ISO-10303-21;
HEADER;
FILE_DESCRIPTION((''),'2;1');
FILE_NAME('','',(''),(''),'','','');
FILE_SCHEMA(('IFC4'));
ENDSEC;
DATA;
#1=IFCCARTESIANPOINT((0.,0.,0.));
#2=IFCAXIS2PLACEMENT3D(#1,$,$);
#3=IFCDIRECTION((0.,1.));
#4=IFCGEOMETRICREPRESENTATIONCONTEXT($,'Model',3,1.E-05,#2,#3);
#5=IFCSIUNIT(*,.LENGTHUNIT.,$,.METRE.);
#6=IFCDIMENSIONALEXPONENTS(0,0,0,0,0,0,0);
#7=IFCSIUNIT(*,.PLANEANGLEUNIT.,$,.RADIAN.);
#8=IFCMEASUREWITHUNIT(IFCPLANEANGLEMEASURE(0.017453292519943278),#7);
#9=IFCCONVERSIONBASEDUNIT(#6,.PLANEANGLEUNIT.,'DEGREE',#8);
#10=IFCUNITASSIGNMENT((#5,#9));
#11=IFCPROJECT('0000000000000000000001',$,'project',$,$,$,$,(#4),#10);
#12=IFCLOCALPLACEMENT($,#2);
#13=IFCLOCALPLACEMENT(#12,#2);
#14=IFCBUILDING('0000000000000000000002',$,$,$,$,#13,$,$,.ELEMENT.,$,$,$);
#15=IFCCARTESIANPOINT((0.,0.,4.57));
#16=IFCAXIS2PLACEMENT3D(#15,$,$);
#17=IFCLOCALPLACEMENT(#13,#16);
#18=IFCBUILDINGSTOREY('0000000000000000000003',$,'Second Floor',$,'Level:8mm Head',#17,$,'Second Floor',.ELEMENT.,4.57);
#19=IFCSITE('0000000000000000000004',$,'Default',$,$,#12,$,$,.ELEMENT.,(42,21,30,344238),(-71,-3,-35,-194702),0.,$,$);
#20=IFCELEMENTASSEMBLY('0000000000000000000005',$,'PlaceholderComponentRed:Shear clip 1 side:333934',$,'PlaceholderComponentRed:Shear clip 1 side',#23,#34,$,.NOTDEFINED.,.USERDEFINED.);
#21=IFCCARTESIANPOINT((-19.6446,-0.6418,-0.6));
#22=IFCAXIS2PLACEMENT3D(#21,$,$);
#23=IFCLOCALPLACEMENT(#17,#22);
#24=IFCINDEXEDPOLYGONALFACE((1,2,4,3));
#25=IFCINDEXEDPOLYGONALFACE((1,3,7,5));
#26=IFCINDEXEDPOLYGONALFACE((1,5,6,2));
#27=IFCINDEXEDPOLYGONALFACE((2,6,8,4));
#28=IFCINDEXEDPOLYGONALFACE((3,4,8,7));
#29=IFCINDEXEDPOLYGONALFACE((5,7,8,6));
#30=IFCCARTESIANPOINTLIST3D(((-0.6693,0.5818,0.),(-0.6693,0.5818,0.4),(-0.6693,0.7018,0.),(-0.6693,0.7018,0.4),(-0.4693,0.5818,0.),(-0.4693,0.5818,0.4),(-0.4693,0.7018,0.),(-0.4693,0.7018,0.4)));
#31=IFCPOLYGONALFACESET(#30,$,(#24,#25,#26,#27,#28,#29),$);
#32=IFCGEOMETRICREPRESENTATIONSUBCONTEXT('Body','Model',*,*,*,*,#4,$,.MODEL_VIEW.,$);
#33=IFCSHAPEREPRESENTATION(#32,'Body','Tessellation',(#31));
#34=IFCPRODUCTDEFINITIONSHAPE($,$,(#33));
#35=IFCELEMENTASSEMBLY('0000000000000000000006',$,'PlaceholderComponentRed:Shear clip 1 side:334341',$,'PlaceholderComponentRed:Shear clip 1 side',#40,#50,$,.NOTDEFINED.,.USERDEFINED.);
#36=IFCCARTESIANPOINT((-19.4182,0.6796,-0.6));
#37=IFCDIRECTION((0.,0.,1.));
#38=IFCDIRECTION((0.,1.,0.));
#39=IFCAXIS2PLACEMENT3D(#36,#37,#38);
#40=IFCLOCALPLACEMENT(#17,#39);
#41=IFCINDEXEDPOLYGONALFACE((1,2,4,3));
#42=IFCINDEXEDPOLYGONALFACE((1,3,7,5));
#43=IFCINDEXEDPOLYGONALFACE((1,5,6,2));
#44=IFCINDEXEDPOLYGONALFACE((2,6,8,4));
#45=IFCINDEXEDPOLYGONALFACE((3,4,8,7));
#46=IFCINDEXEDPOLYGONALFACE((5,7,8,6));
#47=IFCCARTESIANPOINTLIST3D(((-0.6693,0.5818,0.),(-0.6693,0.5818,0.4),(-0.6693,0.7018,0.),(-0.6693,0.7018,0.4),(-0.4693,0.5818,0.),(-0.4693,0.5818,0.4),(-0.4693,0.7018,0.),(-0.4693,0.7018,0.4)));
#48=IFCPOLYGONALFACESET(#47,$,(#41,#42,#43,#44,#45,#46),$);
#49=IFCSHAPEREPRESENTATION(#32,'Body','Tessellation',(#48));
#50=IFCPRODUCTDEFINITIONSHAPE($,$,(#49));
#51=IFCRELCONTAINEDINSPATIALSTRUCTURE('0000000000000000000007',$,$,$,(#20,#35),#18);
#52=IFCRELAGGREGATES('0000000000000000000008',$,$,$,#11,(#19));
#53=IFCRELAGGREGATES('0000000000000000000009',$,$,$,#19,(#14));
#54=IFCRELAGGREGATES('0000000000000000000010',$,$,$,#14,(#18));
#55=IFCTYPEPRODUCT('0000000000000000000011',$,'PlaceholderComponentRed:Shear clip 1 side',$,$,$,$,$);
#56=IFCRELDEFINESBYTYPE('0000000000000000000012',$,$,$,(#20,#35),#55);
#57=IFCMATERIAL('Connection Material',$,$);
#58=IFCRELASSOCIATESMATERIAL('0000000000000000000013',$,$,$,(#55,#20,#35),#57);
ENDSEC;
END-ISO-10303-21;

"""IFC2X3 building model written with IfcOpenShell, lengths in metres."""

from ifc_helpers import new_model, entity, si_unit, converted_unit, direction, frame, frame_2d, origin, place, context, subcontext, project, spatial, rectangle, extrude, source, transform, mapped, material, type_object, type_shapes, element, save


model = new_model("IFC2X3")

# Units and contexts
model_context = context("Model", 3, precision=1e-05, world=origin(), true_north=direction((0.0, 1.0)))
body_context = subcontext(model_context, "Body", "Model", "MODEL_VIEW")
ifc_project = project(units=[si_unit("LENGTHUNIT", "METRE"), converted_unit("PLANEANGLEUNIT", "DEGREE", entity("IfcPlaneAngleMeasure", 0.017453292519943278), si_unit("PLANEANGLEUNIT", "RADIAN"), dimensions=[0, 0, 0, 0, 0, 0, 0])], contexts=[model_context])

# Site, building, storey
site_placement = place(None, origin())
site = spatial("IfcSite", under=ifc_project, at=site_placement, Name="Default", CompositionType="ELEMENT", RefLatitude=(42, 21, 30, 344238), RefLongitude=(-71, -3, -35, -194702), RefElevation=0.0)
building_placement = place(site_placement, origin())
building = spatial("IfcBuilding", under=site, at=building_placement, CompositionType="ELEMENT")
storey_placement = place(building_placement, frame((0.0, 0.0, 4.57)))
storey = spatial("IfcBuildingStorey", under=building, at=storey_placement, Name="Second Floor", ObjectType="Level:8mm Head", LongName="Second Floor", CompositionType="ELEMENT", Elevation=4.57)

# Element assemblies
ifc_material_1 = material(Name="Connection Material")
type_product = type_object("IfcTypeProduct", Name="PlaceholderComponentRed:Shear clip 1 side", material=ifc_material_1)
shared_shape = source(origin(), body_context, "Body", "SweptSolid", [
    extrude(rectangle(XDim=0.12, YDim=0.2, at=frame_2d((0.0, 0.0), x_axis=(1.0, 0.0))), frame((-0.5693, 0.6418, 0.0), z_axis=(0.0, 0.0, 1.0), x_axis=(0.0, 1.0, 0.0)), (0.0, 0.0, 1.0), 0.4),
])
type_shapes(type_product, [shared_shape])
assembly_1_placement = place(storey_placement, frame((-19.6446, -0.6418, -0.6)))
element("IfcElementAssembly", 1, at=assembly_1_placement, inside=storey, type_object=type_product, material=ifc_material_1, Name="PlaceholderComponentRed:Shear clip 1 side:333934", ObjectType="PlaceholderComponentRed:Shear clip 1 side", AssemblyPlace="NOTDEFINED", PredefinedType="USERDEFINED", context=body_context, shape_type="MappedRepresentation", body=[
    mapped(shared_shape, transform((0.0, 0.0, 0.0), scale=1.0)),
])
assembly_2_placement = place(storey_placement, frame((-19.4182, 0.6796, -0.6), z_axis=(0.0, 0.0, 1.0), x_axis=(0.0, 1.0, 0.0)))
element("IfcElementAssembly", 2, at=assembly_2_placement, inside=storey, type_object=type_product, material=ifc_material_1, Name="PlaceholderComponentRed:Shear clip 1 side:334341", ObjectType="PlaceholderComponentRed:Shear clip 1 side", AssemblyPlace="NOTDEFINED", PredefinedType="USERDEFINED", context=body_context, shape_type="MappedRepresentation", body=[
    mapped(shared_shape, transform((0.0, 0.0, 0.0), scale=1.0)),
])

save(model, "model.ifc")
